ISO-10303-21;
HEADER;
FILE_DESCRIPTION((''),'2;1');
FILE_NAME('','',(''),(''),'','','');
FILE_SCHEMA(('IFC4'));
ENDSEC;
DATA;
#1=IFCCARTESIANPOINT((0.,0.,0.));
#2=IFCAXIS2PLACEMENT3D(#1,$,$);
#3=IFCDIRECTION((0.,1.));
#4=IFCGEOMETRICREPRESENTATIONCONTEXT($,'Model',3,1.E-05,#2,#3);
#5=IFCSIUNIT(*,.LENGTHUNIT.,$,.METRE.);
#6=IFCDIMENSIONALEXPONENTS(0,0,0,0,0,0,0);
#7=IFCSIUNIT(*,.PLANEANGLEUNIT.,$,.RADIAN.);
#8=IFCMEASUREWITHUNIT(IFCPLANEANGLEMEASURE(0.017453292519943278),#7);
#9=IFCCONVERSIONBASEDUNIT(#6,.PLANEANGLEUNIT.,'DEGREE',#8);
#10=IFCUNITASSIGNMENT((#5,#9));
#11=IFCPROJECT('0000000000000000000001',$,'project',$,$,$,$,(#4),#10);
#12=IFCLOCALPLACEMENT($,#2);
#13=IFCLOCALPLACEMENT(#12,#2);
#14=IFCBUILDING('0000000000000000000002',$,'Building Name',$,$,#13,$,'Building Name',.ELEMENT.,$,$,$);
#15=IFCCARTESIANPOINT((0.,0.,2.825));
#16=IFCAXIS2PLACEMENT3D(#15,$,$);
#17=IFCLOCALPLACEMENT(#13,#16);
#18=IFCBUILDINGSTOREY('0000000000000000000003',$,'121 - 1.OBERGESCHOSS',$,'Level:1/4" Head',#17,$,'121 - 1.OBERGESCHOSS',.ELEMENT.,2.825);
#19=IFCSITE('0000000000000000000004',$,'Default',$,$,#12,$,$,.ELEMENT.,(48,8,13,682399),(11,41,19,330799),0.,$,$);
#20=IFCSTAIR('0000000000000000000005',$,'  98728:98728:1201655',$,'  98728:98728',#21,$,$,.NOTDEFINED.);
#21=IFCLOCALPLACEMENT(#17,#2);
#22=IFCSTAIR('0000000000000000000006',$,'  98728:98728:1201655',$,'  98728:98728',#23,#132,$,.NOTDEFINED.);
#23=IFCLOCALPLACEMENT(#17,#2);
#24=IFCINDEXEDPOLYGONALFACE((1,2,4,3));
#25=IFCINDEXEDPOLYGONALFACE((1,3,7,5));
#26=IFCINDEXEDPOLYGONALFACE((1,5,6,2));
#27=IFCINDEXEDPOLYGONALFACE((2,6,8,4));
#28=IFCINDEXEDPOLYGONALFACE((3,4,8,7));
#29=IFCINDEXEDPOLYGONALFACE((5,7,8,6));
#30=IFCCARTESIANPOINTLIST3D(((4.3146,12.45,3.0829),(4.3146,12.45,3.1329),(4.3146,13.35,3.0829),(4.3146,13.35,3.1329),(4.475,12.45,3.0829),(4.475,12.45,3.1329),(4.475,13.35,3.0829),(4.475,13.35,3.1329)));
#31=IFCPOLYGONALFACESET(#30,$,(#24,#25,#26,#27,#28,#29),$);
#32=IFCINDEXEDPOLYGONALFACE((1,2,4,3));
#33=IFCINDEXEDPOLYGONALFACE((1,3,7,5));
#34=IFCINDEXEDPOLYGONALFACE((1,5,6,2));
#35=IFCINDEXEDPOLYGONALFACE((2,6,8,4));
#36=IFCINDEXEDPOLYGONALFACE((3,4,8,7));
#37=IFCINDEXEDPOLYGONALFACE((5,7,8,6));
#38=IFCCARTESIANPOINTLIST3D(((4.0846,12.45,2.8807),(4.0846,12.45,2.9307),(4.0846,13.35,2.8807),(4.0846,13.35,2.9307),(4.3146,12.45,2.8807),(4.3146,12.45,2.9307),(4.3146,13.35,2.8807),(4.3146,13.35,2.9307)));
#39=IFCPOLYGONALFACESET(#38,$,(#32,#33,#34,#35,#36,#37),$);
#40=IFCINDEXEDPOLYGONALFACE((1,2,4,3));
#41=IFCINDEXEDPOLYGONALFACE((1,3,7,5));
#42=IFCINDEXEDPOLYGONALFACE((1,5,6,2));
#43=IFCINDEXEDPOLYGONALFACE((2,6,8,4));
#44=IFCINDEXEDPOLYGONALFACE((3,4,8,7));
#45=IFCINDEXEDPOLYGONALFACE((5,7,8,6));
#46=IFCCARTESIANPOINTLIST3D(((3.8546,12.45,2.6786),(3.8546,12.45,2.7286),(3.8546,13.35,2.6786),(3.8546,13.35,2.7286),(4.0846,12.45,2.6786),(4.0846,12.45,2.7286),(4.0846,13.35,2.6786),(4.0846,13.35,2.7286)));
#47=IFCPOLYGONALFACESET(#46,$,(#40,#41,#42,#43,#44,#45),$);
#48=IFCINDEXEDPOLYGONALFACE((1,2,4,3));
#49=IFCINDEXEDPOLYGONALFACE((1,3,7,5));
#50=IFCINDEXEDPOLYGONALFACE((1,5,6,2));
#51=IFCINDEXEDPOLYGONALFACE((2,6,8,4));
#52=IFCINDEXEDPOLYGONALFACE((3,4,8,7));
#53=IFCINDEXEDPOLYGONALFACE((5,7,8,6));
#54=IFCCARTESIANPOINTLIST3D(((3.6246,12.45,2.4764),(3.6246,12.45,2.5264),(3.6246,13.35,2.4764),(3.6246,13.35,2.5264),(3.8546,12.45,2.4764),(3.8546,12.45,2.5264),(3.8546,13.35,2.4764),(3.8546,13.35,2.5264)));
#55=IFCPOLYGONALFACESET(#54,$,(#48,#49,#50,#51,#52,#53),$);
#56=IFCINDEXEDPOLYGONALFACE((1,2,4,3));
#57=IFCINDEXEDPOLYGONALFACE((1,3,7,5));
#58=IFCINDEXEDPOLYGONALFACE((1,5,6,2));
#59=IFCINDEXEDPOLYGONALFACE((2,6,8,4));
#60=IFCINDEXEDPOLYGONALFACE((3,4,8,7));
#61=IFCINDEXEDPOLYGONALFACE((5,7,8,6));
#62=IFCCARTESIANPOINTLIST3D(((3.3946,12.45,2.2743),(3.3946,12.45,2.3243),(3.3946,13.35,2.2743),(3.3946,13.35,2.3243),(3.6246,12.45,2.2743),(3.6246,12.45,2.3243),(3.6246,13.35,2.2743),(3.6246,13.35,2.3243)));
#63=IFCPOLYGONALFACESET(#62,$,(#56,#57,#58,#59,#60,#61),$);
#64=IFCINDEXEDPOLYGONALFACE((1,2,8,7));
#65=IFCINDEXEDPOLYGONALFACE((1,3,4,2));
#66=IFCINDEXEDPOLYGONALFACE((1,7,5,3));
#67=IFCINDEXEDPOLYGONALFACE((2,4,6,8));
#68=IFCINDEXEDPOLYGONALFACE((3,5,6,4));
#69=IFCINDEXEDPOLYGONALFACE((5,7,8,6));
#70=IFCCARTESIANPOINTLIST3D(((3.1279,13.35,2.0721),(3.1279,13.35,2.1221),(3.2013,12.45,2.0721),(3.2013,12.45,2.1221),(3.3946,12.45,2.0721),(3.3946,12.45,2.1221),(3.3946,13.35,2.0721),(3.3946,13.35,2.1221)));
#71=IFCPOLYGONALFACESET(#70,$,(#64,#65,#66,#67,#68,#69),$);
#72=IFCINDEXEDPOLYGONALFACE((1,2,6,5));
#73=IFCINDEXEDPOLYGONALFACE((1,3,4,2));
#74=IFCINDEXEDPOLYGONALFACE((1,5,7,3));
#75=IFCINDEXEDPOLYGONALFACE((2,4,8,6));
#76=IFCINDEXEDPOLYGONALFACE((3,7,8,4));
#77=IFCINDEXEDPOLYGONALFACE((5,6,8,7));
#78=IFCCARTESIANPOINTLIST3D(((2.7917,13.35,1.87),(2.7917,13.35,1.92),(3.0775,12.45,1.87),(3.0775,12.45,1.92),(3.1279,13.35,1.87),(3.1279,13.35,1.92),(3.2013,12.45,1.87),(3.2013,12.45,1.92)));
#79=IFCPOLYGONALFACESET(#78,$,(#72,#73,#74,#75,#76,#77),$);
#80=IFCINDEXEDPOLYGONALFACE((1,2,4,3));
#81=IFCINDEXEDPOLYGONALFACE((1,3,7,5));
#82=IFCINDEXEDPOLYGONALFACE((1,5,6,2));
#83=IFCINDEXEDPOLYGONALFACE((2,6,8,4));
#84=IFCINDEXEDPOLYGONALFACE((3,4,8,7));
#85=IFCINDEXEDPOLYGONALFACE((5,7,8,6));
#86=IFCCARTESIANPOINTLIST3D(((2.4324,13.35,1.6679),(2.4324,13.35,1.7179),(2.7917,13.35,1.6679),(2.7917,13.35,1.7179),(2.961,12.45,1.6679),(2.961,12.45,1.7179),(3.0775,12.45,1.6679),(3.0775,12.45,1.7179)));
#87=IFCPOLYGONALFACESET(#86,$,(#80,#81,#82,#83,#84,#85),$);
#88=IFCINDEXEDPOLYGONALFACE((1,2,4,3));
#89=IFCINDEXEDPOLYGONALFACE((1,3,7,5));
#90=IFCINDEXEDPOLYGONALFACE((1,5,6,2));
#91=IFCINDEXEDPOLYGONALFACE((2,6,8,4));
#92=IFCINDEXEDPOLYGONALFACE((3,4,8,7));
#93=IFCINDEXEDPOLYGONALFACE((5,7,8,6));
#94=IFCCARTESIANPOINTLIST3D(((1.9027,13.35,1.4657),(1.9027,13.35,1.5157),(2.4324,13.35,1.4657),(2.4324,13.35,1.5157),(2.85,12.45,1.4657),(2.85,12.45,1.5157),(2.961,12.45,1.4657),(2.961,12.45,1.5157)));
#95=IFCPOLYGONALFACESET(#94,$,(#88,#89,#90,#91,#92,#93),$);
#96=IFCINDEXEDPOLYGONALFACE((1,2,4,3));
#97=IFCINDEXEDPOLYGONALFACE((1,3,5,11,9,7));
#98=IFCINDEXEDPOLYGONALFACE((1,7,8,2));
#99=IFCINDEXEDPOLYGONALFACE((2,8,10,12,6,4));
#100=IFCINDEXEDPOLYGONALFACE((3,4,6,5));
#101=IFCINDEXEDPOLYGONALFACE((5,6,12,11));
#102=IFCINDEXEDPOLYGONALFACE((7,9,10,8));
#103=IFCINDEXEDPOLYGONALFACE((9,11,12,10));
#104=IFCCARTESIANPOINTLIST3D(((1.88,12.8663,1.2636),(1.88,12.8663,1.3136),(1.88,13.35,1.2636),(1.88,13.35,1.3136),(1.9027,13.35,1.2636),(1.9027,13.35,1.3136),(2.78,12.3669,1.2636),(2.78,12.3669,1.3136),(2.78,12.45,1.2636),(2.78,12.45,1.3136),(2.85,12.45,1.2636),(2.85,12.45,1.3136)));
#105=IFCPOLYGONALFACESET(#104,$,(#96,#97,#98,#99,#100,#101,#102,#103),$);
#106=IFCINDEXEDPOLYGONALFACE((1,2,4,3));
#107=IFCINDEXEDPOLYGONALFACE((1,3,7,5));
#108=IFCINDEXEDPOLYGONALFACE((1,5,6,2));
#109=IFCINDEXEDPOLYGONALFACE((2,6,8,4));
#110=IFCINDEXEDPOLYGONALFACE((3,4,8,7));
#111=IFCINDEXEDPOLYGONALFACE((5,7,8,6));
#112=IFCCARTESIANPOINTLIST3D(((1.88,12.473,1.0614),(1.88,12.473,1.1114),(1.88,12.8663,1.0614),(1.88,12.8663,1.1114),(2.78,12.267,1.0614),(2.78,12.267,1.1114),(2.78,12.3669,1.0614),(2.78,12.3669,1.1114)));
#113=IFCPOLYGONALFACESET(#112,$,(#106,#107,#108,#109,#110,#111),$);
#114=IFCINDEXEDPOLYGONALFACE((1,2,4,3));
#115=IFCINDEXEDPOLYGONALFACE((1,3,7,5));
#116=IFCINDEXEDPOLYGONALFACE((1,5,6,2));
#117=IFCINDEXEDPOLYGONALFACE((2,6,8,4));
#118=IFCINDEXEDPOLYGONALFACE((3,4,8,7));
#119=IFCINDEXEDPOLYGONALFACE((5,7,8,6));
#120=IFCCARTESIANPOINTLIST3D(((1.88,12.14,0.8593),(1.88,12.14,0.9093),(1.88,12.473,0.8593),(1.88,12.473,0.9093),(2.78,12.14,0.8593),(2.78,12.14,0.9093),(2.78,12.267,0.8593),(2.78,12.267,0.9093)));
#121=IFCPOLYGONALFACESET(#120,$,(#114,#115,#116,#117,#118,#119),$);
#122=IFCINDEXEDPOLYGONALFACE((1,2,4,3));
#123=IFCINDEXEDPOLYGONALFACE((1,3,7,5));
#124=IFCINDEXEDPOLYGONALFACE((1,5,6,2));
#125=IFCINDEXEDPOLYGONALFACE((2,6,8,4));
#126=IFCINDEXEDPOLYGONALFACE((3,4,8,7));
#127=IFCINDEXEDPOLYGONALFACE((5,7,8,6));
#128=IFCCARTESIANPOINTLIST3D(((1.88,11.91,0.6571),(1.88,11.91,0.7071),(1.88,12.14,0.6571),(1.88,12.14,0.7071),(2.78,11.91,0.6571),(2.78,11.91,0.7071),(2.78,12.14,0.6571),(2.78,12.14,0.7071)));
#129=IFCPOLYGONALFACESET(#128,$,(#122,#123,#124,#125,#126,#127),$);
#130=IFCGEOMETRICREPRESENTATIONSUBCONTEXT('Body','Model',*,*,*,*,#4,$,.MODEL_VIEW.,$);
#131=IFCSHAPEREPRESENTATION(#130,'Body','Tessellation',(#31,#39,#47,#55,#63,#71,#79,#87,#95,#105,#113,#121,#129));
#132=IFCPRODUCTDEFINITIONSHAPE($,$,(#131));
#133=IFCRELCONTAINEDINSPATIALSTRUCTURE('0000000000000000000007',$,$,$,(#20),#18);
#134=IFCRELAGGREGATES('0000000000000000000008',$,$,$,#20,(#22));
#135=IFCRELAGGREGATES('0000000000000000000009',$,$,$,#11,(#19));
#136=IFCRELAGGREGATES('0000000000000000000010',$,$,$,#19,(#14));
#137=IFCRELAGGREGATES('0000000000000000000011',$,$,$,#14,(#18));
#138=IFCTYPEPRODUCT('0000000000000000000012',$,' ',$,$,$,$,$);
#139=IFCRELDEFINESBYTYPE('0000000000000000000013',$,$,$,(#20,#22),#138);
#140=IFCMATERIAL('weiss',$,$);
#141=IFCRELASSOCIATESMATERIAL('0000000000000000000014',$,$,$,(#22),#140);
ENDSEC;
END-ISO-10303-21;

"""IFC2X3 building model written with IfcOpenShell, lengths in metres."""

from ifc_helpers import new_model, entity, si_unit, converted_unit, direction, frame, origin, origin_2d_with_axis, place, context, subcontext, project, spatial, polyline, rectangle, outline, extrude, material, type_object, element, aggregate, save


model = new_model("IFC2X3")

# Units and contexts
model_context = context("Model", 3, precision=1e-05, world=origin(), true_north=direction((0.0, 1.0)))
body_context = subcontext(model_context, "Body", "Model", "MODEL_VIEW")
ifc_project = project(units=[si_unit("LENGTHUNIT", "METRE"), converted_unit("PLANEANGLEUNIT", "DEGREE", entity("IfcPlaneAngleMeasure", 0.017453292519943278), si_unit("PLANEANGLEUNIT", "RADIAN"), dimensions=[0, 0, 0, 0, 0, 0, 0])], contexts=[model_context])

# Site, building, storey
site_placement = place(None, origin())
site = spatial("IfcSite", under=ifc_project, at=site_placement, Name="Default", CompositionType="ELEMENT", RefLatitude=(48, 8, 13, 682399), RefLongitude=(11, 41, 19, 330799), RefElevation=0.0)
building_placement = place(site_placement, origin())
building = spatial("IfcBuilding", under=site, at=building_placement, Name="Building Name", LongName="Building Name", CompositionType="ELEMENT")
storey_placement = place(building_placement, frame((0.0, 0.0, 2.825)))
storey = spatial("IfcBuildingStorey", under=building, at=storey_placement, Name="121 - 1.OBERGESCHOSS", ObjectType="Level:1/4\" Head", LongName="121 - 1.OBERGESCHOSS", CompositionType="ELEMENT", Elevation=2.825)

# Stairs
ifc_material_1 = material(Name="weiss")
type_product_1 = type_object("IfcTypeProduct", Name=" ")
stair_1_placement = place(storey_placement, origin())
stair_1 = element("IfcStair", 1, at=stair_1_placement, inside=storey, type_object=type_product_1, Name="  98728:98728:1201655", ObjectType="  98728:98728", ShapeType="NOTDEFINED")
stair_2_placement = place(stair_1_placement, origin())
stair_2 = element("IfcStair", 2, at=stair_2_placement, type_object=type_product_1, material=ifc_material_1, Name="  98728:98728:1201655", ObjectType="  98728:98728", ShapeType="NOTDEFINED", context=body_context, shape_type="SweptSolid", body=[
    extrude(rectangle(XDim=0.1604, YDim=0.9, at=origin_2d_with_axis()), frame((4.3948, 12.9, 3.0829), z_axis=(0.0, 0.0, 1.0), x_axis=(-1.0, 0.0, 0.0)), (0.0, 0.0, 1.0), 0.05),
    extrude(rectangle(XDim=0.23, YDim=0.9, at=origin_2d_with_axis()), frame((4.1996, 12.9, 2.8807), z_axis=(0.0, 0.0, 1.0), x_axis=(-1.0, 0.0, 0.0)), (0.0, 0.0, 1.0), 0.05),
    extrude(rectangle(XDim=0.23, YDim=0.9, at=origin_2d_with_axis()), frame((3.9696, 12.9, 2.6786), z_axis=(0.0, 0.0, 1.0), x_axis=(-1.0, 0.0, 0.0)), (0.0, 0.0, 1.0), 0.05),
    extrude(rectangle(XDim=0.23, YDim=0.9, at=origin_2d_with_axis()), frame((3.7396, 12.9, 2.4764), z_axis=(0.0, 0.0, 1.0), x_axis=(-1.0, 0.0, 0.0)), (0.0, 0.0, 1.0), 0.05),
    extrude(rectangle(XDim=0.23, YDim=0.9, at=origin_2d_with_axis()), frame((3.5096, 12.9, 2.2743), z_axis=(0.0, 0.0, 1.0), x_axis=(-1.0, 0.0, 0.0)), (0.0, 0.0, 1.0), 0.05),
    extrude(outline(polyline([(-0.115, -0.45), (0.1517, -0.45), (0.0783, 0.45), (-0.115, 0.45), (-0.115, -0.45)])), frame((3.2796, 12.9, 2.0721), z_axis=(0.0, 0.0, 1.0), x_axis=(-1.0, 0.0, 0.0)), (0.0, 0.0, 1.0), 0.05),
    extrude(outline(polyline([(-0.0783, -0.45), (0.2579, -0.45), (-0.0279, 0.45), (-0.1517, 0.45), (-0.0783, -0.45)])), frame((3.0496, 12.9, 1.87), z_axis=(0.0, 0.0, 1.0), x_axis=(-1.0, 0.0, 0.0)), (0.0, 0.0, 1.0), 0.05),
    extrude(outline(polyline([(0.024, -0.45), (0.3832, -0.45), (-0.1453, 0.45), (-0.2619, 0.45), (0.024, -0.45)])), frame((2.8157, 12.9, 1.6679), z_axis=(0.0, 0.0, 1.0), x_axis=(-1.0, 0.0, 0.0)), (0.0, 0.0, 1.0), 0.05),
    extrude(outline(polyline([(0.1041, -0.45), (0.6339, -0.45), (-0.3135, 0.45), (-0.4245, 0.45), (0.1041, -0.45)])), frame((2.5365, 12.9, 1.4657), z_axis=(0.0, 0.0, 1.0), x_axis=(-1.0, 0.0, 0.0)), (0.0, 0.0, 1.0), 0.05),
    extrude(outline(polyline([(-0.5445, -0.4654), (-0.0608, -0.4654), (0.4386, 0.4346), (0.3555, 0.4346), (0.3555, 0.5046), (-0.5445, -0.4428), (-0.5445, -0.4654)])), frame((2.3454, 12.8055, 1.2636), z_axis=(0.0, 0.0, 1.0), x_axis=(0.0, -1.0, 0.0)), (0.0, 0.0, 1.0), 0.05),
    extrude(outline(polyline([(-0.373, -0.45), (0.0203, -0.45), (0.2263, 0.45), (0.1264, 0.45), (-0.373, -0.45)])), frame((2.33, 12.4933, 1.0614), z_axis=(0.0, 0.0, 1.0), x_axis=(0.0, -1.0, 0.0)), (0.0, 0.0, 1.0), 0.05),
    extrude(outline(polyline([(-0.218, -0.45), (0.115, -0.45), (0.115, 0.45), (-0.012, 0.45), (-0.218, -0.45)])), frame((2.33, 12.255, 0.8593), z_axis=(0.0, 0.0, 1.0), x_axis=(0.0, -1.0, 0.0)), (0.0, 0.0, 1.0), 0.05),
    extrude(rectangle(XDim=0.23, YDim=0.9, at=origin_2d_with_axis()), frame((2.33, 12.025, 0.6571), z_axis=(0.0, 0.0, 1.0), x_axis=(0.0, -1.0, 0.0)), (0.0, 0.0, 1.0), 0.05),
])
aggregate(stair_1, [stair_2])

save(model, "model.ifc")
